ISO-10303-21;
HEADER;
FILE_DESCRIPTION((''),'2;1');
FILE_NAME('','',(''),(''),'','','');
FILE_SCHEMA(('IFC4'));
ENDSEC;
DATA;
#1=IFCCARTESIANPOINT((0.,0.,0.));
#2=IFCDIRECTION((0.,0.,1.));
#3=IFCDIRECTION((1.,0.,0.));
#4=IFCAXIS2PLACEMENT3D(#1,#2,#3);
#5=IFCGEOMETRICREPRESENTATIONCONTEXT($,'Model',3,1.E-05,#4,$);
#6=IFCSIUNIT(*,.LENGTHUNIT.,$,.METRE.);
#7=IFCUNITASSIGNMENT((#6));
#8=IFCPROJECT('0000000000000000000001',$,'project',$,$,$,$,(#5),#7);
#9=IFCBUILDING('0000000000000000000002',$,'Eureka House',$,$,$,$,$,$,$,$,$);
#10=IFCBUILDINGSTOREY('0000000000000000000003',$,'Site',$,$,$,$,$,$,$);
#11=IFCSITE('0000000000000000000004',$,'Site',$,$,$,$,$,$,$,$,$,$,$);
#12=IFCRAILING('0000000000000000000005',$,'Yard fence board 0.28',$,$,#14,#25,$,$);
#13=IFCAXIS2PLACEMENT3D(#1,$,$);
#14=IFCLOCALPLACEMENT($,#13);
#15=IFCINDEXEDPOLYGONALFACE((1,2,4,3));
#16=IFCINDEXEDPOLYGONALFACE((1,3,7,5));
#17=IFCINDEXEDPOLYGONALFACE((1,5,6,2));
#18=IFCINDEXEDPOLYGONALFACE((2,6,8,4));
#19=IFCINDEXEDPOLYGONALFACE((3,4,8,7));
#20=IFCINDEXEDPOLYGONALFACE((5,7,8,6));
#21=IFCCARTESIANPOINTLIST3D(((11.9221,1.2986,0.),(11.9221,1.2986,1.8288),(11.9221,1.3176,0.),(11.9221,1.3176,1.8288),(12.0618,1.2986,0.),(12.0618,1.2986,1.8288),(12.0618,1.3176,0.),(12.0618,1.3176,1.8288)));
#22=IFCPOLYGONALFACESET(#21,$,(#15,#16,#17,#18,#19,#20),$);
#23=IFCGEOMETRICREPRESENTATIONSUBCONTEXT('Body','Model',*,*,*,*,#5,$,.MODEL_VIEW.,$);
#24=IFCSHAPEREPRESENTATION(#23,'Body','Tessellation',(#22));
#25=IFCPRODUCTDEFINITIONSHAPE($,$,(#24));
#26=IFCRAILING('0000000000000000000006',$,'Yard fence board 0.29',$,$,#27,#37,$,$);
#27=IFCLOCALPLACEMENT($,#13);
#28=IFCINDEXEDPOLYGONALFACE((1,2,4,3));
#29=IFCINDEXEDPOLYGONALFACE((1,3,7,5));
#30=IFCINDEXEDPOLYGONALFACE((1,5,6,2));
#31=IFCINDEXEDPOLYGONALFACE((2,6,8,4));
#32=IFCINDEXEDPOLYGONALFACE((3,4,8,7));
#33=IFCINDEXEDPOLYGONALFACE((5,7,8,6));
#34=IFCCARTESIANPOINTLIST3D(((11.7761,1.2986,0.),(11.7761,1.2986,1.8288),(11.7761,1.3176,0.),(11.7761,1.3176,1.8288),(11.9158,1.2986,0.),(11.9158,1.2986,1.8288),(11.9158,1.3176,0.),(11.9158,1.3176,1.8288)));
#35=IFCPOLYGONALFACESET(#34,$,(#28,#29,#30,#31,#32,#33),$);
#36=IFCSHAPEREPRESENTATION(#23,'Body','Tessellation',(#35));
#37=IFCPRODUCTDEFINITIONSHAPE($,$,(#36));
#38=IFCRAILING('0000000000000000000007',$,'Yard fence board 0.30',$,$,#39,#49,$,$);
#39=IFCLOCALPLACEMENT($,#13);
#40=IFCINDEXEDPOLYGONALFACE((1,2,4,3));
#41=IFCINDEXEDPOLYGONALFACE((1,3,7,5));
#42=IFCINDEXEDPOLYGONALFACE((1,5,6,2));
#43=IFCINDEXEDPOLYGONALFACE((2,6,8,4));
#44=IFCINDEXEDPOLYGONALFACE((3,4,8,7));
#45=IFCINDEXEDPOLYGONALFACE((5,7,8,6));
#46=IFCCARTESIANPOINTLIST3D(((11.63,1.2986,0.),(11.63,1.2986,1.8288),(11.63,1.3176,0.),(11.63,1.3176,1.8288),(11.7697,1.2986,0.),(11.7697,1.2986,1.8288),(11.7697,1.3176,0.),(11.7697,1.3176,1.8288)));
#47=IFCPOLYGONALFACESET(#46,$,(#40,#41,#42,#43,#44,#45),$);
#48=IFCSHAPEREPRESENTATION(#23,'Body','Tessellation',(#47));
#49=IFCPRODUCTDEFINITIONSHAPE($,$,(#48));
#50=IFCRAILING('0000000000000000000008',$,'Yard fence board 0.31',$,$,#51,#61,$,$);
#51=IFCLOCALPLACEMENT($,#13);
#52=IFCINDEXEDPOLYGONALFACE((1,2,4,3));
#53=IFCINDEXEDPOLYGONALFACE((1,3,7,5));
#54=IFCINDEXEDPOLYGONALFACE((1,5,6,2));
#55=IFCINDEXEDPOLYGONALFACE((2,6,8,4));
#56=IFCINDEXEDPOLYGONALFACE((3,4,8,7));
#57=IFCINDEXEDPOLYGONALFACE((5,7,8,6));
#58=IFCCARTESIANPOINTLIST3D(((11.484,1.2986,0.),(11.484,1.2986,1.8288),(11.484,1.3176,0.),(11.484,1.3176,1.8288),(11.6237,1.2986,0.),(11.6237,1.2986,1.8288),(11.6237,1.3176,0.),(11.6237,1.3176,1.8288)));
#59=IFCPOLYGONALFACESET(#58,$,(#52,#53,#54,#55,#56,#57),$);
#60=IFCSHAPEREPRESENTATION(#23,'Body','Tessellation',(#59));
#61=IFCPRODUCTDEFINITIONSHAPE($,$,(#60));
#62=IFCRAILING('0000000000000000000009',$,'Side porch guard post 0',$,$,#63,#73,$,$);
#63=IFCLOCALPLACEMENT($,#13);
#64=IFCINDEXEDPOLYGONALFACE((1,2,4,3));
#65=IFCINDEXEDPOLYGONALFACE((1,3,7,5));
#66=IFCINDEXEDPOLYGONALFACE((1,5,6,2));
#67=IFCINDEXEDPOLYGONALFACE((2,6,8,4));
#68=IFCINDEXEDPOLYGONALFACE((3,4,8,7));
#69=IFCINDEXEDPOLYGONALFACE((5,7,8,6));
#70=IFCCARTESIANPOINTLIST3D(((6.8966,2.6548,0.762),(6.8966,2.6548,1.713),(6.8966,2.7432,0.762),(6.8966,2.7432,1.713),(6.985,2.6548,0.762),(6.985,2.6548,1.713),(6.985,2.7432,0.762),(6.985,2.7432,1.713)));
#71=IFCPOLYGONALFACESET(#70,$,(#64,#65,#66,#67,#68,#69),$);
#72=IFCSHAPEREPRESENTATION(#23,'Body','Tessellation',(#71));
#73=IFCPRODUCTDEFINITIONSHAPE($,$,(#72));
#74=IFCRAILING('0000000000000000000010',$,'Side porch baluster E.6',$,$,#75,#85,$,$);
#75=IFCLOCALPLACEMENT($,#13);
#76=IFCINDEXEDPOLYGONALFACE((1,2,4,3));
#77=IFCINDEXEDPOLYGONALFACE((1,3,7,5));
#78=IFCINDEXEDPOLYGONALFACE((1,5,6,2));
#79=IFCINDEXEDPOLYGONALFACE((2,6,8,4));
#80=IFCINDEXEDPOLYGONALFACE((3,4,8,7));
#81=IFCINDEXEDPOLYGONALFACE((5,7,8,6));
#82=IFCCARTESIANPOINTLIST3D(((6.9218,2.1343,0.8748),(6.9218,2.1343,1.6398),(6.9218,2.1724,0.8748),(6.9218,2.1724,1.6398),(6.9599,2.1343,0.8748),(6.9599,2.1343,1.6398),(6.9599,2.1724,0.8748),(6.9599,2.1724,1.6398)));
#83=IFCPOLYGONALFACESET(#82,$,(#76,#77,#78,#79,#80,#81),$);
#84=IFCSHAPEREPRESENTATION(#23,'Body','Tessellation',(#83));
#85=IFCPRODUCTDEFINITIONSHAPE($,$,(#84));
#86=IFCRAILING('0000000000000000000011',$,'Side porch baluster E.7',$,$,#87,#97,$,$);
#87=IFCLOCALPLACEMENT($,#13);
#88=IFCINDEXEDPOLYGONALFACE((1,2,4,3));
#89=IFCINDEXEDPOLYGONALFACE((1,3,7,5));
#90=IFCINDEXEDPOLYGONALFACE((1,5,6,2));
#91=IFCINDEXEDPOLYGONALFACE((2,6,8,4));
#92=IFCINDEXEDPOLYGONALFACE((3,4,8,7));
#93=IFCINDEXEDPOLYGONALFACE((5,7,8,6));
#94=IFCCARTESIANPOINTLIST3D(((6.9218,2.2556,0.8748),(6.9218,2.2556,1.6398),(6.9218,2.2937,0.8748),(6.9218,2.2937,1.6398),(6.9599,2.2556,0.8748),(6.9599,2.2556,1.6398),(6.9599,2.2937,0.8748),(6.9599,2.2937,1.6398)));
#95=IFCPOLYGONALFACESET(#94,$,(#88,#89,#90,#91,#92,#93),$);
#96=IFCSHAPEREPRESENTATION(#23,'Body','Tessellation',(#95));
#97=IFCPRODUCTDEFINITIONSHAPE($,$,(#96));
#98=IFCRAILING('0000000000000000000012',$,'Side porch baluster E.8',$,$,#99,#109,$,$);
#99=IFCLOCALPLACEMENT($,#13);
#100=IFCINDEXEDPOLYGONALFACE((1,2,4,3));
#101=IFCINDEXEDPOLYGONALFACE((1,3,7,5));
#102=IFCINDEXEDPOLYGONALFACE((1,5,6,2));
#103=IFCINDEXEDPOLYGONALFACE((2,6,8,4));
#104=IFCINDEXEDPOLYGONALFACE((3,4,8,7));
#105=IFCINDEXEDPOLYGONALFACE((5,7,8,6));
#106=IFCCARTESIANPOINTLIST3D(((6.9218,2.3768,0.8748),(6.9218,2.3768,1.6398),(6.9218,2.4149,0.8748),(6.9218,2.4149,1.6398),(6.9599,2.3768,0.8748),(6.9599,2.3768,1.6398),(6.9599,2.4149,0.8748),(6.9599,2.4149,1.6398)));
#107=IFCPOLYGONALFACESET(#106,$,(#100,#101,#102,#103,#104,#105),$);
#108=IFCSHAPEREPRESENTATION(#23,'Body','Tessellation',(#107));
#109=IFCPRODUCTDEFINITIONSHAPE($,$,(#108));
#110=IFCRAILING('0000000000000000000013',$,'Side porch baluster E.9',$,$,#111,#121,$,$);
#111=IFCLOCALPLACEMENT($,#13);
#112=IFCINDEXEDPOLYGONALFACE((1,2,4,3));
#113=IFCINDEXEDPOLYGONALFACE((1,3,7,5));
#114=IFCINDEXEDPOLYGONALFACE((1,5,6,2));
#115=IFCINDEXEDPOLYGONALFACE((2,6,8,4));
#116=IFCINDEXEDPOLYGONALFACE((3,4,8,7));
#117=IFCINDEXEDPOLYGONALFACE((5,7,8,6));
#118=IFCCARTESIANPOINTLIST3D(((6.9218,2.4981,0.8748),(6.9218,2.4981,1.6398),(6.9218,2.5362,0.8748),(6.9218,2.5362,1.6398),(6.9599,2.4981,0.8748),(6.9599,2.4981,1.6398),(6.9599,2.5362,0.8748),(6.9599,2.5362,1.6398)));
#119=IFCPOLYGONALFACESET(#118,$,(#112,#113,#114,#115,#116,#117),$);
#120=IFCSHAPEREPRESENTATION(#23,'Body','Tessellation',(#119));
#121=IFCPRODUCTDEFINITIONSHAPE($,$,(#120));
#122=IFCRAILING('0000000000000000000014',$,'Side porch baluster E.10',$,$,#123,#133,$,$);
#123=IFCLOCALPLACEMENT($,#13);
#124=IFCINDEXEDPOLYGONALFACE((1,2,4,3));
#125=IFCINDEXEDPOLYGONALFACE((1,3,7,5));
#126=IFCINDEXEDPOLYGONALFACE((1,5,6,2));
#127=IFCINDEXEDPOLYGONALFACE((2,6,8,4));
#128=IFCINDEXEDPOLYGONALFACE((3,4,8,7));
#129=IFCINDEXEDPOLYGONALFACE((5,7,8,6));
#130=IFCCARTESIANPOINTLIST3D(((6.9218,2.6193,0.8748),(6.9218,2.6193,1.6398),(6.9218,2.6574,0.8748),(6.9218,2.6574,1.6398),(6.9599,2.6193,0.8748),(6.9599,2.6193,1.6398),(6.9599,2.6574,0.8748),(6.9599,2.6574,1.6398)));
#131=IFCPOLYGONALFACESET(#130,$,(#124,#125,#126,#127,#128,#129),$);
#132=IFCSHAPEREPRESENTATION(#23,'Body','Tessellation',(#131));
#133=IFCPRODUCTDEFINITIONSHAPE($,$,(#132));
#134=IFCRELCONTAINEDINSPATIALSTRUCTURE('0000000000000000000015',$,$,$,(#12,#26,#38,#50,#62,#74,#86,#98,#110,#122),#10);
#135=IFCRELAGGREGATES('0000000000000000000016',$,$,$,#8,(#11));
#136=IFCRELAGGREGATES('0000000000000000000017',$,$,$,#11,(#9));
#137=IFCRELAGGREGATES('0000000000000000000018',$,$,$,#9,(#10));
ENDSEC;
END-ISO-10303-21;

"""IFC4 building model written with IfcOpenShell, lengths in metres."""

from ifc_helpers import new_model, si_unit, frame, origin, origin_with_axes, origin_2d, place, context, subcontext, project, spatial, rectangle, extrude, element, save


model = new_model("IFC4")

# Units and contexts
model_context = context("Model", 3, precision=1e-05, world=origin_with_axes())
body_context = subcontext(model_context, "Body", "Model", "MODEL_VIEW")
ifc_project = project(units=[si_unit("LENGTHUNIT", "METRE")], contexts=[model_context])

# Site, building, storey
site = spatial("IfcSite", under=ifc_project, Name="Site")
building = spatial("IfcBuilding", under=site, Name="Eureka House")
storey = spatial("IfcBuildingStorey", under=building, Name="Site")

# Railings
for number, where, z_axis, x_axis, name in (
    (1, (11.992, 1.3081, 0.0), (0.0, 0.0, 1.0), (1.0, 0.0, 0.0), "Yard fence board 0.28"),
    (2, (11.8459, 1.3081, 0.0), (0.0, 0.0, 1.0), (1.0, 0.0, 0.0), "Yard fence board 0.29"),
    (3, (11.6999, 1.3081, 0.0), (0.0, 0.0, 1.0), (1.0, 0.0, 0.0), "Yard fence board 0.30"),
    (4, (11.5538, 1.3081, 0.0), (0.0, 0.0, 1.0), (1.0, 0.0, 0.0), "Yard fence board 0.31"),
):
    element("IfcRailing", number, at=place(None, frame(where, z_axis=z_axis, x_axis=x_axis)), inside=storey, Name=name, context=body_context, shape_type="SweptSolid", body=[
        extrude(rectangle(XDim=0.1397, YDim=0.0191, at=origin_2d()), origin(), (0.0, 0.0, 1.0), 1.8288),
    ])
railing_placement = place(None, frame((6.9408, 2.699, 0.762), z_axis=(0.0, 0.0, 1.0), x_axis=(1.0, 0.0, 0.0)))
element("IfcRailing", 5, at=railing_placement, inside=storey, Name="Side porch guard post 0", context=body_context, shape_type="SweptSolid", body=[
    extrude(rectangle(XDim=0.0884, YDim=0.0884, at=origin_2d()), origin(), (0.0, 0.0, 1.0), 0.951),
])
for number, where, z_axis, x_axis, name in (
    (6, (6.9408, 2.1534, 0.8748), (0.0, 0.0, 1.0), (1.0, 0.0, 0.0), "Side porch baluster E.6"),
    (7, (6.9408, 2.2746, 0.8748), (0.0, 0.0, 1.0), (1.0, 0.0, 0.0), "Side porch baluster E.7"),
    (8, (6.9408, 2.3959, 0.8748), (0.0, 0.0, 1.0), (1.0, 0.0, 0.0), "Side porch baluster E.8"),
    (9, (6.9408, 2.5171, 0.8748), (0.0, 0.0, 1.0), (1.0, 0.0, 0.0), "Side porch baluster E.9"),
    (10, (6.9408, 2.6384, 0.8748), (0.0, 0.0, 1.0), (1.0, 0.0, 0.0), "Side porch baluster E.10"),
):
    element("IfcRailing", number, at=place(None, frame(where, z_axis=z_axis, x_axis=x_axis)), inside=storey, Name=name, context=body_context, shape_type="SweptSolid", body=[
        extrude(rectangle(XDim=0.0381, YDim=0.0381, at=origin_2d()), origin(), (0.0, 0.0, 1.0), 0.765),
    ])

save(model, "model.ifc")
